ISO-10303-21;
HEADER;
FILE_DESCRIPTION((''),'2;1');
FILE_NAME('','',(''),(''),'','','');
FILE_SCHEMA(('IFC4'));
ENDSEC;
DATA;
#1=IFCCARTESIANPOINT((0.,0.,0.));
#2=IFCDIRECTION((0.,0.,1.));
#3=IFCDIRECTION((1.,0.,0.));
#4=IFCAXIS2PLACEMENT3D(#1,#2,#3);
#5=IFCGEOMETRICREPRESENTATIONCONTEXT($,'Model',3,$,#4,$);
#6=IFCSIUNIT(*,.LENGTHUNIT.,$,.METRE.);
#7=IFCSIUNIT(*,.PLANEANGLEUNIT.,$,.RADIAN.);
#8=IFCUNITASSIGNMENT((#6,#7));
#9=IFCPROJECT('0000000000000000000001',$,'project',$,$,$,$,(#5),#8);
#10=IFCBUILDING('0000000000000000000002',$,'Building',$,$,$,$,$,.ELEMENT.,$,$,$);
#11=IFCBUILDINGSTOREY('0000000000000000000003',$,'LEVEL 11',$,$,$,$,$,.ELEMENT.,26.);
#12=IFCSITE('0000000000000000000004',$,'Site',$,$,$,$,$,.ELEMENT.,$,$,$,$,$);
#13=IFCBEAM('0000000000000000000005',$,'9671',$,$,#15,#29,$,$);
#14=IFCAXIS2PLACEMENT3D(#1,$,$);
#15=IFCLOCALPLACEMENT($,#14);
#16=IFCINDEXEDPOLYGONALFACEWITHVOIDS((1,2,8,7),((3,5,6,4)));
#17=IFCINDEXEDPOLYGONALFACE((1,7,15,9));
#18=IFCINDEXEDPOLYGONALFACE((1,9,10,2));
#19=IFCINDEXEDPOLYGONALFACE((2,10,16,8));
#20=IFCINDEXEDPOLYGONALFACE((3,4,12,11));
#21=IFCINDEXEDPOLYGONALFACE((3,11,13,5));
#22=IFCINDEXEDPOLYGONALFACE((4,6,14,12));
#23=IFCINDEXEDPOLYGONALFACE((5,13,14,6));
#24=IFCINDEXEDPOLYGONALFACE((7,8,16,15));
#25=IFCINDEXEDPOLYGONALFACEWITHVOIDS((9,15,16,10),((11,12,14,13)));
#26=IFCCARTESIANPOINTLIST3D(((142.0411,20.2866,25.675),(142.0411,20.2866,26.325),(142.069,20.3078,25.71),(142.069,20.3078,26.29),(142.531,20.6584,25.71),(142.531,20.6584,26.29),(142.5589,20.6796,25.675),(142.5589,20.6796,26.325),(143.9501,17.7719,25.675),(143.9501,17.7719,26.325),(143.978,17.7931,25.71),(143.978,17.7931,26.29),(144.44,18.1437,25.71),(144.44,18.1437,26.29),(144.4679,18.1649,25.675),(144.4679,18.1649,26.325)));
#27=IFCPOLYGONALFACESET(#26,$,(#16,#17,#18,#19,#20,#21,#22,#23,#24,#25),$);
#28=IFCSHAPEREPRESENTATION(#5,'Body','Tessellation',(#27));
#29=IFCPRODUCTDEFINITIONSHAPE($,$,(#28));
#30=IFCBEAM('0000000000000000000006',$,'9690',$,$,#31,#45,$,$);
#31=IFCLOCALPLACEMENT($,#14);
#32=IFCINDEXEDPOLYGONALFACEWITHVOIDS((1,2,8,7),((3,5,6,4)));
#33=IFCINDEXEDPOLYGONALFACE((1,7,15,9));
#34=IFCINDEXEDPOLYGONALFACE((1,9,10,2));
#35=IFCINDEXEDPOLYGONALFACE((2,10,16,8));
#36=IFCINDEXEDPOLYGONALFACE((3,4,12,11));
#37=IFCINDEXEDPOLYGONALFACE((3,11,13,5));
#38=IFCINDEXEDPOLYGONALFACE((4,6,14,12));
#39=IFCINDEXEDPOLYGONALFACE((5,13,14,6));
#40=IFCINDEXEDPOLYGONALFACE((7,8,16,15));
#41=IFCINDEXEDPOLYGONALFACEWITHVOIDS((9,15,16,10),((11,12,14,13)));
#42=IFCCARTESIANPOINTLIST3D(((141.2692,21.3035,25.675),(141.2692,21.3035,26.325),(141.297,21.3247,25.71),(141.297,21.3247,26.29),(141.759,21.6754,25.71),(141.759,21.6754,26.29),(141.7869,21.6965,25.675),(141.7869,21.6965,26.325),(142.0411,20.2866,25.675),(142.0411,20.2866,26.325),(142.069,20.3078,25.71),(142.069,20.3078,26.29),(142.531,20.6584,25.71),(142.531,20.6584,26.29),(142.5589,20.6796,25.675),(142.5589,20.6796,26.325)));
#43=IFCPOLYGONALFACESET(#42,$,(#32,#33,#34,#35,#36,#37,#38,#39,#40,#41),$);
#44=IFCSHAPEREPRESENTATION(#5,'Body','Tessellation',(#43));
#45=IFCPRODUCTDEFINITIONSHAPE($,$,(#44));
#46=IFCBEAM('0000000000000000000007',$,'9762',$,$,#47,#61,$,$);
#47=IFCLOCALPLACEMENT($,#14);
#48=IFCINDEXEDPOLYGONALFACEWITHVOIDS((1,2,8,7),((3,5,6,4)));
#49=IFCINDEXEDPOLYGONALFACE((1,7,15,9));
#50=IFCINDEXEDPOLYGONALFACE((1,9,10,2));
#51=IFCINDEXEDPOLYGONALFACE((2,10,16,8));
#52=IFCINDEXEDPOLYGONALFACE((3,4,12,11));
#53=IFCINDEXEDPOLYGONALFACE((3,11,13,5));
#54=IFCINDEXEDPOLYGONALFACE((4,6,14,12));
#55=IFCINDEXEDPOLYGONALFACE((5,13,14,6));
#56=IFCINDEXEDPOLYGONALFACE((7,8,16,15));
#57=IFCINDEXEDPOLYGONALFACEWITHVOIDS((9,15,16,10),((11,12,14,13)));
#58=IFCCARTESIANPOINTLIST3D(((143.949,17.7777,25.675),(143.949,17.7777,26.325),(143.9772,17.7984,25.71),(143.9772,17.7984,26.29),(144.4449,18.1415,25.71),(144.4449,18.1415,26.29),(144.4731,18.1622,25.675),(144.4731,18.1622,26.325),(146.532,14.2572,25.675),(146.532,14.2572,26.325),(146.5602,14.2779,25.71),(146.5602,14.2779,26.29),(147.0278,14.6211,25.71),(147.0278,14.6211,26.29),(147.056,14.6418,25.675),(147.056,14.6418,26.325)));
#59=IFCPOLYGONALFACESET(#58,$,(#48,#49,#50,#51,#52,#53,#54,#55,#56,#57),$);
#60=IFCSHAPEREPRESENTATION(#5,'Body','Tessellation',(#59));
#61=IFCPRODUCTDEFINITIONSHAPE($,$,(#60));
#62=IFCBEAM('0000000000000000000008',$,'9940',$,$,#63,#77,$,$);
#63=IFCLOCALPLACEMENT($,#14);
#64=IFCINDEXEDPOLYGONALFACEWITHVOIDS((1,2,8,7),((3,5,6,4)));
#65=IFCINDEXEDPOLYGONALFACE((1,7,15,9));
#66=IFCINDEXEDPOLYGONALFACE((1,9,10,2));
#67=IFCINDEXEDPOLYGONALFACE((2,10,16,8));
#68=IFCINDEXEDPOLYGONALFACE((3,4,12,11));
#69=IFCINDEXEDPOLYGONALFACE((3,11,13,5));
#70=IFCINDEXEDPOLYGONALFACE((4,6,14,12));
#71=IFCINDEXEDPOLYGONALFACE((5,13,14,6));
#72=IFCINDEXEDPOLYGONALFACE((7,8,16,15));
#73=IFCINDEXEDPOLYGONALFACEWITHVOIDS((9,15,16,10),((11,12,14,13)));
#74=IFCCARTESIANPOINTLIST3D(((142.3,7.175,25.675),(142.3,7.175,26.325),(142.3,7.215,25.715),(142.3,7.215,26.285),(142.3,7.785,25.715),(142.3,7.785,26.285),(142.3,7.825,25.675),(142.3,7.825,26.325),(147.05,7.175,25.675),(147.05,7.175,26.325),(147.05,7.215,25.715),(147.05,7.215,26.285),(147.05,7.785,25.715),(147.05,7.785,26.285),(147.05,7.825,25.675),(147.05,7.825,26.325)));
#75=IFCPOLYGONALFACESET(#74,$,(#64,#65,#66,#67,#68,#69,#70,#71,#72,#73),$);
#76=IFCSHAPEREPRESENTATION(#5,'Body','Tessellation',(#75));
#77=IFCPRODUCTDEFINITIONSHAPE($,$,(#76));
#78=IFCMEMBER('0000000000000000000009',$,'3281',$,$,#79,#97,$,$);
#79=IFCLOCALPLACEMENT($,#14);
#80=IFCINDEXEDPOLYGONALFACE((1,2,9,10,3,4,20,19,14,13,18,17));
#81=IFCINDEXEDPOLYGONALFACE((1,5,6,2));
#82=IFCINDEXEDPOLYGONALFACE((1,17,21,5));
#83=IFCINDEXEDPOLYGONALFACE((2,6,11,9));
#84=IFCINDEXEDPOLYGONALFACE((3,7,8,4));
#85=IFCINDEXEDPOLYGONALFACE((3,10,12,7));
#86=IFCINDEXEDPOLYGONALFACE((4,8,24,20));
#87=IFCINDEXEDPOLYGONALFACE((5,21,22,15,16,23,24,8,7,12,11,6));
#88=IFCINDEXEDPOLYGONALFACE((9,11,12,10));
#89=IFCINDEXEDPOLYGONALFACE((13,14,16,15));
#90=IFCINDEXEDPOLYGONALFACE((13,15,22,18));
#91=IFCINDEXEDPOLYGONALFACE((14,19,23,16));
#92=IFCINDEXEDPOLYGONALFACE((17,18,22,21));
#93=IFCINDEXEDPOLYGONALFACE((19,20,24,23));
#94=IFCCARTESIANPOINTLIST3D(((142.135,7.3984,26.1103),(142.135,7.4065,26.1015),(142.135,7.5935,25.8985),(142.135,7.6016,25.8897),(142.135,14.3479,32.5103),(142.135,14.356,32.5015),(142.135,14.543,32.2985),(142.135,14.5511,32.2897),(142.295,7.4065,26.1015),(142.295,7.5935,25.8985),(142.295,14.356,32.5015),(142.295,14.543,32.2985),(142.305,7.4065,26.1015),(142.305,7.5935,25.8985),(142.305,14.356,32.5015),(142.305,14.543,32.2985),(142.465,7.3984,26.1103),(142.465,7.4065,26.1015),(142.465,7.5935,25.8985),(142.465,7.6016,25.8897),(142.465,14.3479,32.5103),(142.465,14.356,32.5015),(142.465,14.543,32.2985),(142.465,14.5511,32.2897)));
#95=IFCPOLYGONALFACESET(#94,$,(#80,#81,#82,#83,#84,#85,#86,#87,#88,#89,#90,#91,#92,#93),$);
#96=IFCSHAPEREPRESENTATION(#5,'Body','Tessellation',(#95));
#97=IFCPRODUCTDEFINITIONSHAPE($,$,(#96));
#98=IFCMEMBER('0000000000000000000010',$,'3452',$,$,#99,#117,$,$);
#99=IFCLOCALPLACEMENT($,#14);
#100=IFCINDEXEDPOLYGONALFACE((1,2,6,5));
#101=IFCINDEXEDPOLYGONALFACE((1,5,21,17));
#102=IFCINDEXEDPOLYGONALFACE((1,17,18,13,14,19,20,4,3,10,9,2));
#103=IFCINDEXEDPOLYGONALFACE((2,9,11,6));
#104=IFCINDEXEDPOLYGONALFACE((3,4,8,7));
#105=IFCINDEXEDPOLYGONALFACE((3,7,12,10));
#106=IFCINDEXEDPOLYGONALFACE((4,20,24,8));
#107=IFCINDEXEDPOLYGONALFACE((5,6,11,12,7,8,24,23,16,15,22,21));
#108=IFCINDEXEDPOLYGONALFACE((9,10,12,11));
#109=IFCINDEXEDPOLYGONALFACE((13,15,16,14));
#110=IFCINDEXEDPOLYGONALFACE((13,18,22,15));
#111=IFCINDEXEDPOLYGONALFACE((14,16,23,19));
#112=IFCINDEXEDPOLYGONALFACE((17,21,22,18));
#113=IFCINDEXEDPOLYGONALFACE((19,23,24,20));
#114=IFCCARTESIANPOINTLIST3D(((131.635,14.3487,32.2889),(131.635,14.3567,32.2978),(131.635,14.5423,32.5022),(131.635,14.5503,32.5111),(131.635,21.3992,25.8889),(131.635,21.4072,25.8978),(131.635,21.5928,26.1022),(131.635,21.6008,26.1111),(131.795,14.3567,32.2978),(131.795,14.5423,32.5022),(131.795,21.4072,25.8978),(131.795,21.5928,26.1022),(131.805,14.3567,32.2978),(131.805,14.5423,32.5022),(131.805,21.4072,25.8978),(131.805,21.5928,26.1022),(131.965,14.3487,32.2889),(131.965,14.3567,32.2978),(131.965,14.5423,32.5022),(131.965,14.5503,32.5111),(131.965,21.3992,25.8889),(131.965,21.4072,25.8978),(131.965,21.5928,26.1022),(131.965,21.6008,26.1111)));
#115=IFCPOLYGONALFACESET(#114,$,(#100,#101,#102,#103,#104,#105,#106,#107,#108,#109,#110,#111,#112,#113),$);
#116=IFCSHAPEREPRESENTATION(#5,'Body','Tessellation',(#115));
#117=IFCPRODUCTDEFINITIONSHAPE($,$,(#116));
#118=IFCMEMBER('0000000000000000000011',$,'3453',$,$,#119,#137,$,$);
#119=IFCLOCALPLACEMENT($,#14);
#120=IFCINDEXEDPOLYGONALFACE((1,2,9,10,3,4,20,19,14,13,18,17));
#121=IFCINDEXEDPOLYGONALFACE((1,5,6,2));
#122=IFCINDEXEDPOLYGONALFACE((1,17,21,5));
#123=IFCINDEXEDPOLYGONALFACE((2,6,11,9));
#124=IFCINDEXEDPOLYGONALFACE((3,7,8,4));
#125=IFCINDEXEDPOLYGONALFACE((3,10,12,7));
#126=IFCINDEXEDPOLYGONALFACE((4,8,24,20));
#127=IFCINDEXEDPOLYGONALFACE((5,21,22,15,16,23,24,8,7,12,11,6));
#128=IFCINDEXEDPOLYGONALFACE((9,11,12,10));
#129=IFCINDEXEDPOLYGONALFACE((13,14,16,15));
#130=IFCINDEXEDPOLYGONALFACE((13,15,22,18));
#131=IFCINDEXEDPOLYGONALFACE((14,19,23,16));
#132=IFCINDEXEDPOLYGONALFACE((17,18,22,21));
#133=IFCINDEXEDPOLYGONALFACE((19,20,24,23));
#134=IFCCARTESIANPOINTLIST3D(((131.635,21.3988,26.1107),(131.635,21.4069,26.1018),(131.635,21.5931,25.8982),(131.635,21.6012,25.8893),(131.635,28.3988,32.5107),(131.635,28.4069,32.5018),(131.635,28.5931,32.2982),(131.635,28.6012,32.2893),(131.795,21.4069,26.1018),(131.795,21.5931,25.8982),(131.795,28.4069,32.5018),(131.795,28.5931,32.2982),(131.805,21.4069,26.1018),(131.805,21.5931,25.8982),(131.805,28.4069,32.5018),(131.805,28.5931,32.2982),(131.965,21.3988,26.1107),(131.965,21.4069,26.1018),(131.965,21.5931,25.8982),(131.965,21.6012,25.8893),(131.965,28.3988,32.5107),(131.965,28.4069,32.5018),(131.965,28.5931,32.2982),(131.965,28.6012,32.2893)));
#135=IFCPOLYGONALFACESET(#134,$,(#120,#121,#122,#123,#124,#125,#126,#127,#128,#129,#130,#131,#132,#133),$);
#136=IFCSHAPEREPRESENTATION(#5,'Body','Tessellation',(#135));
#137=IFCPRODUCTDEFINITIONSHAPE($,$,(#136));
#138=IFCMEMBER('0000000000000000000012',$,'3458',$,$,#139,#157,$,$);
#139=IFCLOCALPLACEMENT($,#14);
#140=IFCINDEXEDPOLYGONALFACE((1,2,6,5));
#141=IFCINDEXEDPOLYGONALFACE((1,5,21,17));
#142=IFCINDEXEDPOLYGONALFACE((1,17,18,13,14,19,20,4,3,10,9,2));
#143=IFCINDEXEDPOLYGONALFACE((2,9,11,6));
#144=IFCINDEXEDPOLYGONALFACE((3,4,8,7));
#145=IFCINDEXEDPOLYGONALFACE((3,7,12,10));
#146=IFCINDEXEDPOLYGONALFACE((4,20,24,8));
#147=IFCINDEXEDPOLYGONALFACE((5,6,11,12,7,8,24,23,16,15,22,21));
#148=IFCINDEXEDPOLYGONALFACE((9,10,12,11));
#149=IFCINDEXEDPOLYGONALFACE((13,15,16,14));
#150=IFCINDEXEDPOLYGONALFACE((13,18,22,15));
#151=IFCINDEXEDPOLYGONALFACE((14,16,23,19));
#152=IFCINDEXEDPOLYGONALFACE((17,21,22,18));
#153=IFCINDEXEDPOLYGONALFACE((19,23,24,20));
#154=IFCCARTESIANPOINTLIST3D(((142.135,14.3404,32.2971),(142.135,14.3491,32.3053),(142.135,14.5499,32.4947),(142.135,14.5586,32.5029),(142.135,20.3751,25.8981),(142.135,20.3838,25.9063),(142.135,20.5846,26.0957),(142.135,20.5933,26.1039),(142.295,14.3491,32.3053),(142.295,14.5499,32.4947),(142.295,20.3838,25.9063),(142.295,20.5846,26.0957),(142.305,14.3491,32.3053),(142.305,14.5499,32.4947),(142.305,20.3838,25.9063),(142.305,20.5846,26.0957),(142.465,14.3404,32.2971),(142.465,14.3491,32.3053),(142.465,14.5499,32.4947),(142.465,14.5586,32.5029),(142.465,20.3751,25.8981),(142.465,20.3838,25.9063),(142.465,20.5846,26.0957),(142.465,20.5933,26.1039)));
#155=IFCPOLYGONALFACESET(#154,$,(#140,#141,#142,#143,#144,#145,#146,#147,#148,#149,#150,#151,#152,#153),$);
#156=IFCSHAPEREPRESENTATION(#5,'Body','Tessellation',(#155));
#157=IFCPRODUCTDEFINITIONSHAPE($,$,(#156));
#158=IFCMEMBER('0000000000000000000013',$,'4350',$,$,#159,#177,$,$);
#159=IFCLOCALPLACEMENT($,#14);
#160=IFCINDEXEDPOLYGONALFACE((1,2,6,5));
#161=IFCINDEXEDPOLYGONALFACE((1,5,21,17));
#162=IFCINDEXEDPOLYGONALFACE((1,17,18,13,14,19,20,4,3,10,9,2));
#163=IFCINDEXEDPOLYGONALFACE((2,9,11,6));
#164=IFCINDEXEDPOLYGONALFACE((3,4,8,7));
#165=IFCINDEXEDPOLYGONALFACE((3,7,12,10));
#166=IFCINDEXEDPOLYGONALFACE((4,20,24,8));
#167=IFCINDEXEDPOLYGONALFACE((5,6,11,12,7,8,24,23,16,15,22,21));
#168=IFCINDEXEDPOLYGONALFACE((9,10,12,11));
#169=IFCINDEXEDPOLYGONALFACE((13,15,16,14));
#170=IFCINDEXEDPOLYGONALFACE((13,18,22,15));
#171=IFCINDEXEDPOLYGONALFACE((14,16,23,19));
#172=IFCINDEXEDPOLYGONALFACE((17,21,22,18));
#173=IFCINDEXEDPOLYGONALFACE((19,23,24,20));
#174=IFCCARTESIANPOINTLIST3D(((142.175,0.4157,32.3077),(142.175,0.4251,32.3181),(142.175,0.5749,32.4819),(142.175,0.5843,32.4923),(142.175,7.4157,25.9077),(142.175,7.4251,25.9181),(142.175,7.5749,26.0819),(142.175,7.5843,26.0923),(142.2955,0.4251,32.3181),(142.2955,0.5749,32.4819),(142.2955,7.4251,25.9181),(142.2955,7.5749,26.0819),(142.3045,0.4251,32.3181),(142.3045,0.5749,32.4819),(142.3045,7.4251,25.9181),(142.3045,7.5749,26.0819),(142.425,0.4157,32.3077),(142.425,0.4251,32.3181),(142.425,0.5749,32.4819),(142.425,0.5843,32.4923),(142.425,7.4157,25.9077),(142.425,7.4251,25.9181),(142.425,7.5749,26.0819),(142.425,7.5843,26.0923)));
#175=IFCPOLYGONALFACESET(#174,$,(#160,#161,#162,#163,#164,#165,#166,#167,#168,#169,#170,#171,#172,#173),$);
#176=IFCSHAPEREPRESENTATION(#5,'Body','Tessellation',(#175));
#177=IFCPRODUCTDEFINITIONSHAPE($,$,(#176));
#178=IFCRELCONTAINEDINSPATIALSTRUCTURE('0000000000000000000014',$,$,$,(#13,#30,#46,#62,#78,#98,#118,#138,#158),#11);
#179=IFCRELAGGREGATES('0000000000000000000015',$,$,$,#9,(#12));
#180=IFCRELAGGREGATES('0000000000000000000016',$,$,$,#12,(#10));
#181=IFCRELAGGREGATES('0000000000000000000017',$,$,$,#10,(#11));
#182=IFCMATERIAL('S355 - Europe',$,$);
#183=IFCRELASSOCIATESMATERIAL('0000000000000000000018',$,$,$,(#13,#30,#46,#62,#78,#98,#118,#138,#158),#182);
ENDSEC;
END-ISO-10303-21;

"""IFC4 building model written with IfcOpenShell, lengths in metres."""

from ifc_helpers import new_model, si_unit, frame, origin_with_axes, origin_2d_with_axis, place, context, project, spatial, hollow_rectangle, i_section, extrude, material, material_profile, profile_set, profile_usage, element, save


model = new_model("IFC4")

# Units and contexts
model_context = context("Model", 3, world=origin_with_axes())
ifc_project = project(units=[si_unit("LENGTHUNIT", "METRE"), si_unit("PLANEANGLEUNIT", "RADIAN")], contexts=[model_context])

# Site, building, storey
site = spatial("IfcSite", under=ifc_project, Name="Site", CompositionType="ELEMENT")
building = spatial("IfcBuilding", under=site, Name="Building", CompositionType="ELEMENT")
storey = spatial("IfcBuildingStorey", under=building, Name="LEVEL 11", CompositionType="ELEMENT", Elevation=26.0)

# Shared definitions
ifc_material = material(Name="S355 - Europe")

# Beams
ifc_material_profile_1 = material_profile(ifc_material, hollow_rectangle(XDim=0.65, YDim=0.65, WallThickness=0.035, at=origin_2d_with_axis()))
ifc_profile_set_1 = profile_set([ifc_material_profile_1])
ifc_profile_usage_1 = profile_usage(ifc_profile_set_1, cardinal=10)
beam_1_placement = place(None, frame((144.209, 17.9684, 26.0), z_axis=(-0.604647, 0.796493, 0.0), x_axis=(-0.796493, -0.604647, 0.0)))
element("IfcBeam", 1, at=beam_1_placement, inside=storey, material=ifc_profile_usage_1, Name="9671", context=model_context, shape_type="SweptSolid", body=[
    extrude(hollow_rectangle(XDim=0.65, YDim=0.65, WallThickness=0.035, at=origin_2d_with_axis()), origin_with_axes(), (0.0, 0.0, 1.0), 3.1572),
])
ifc_material_profile_2 = material_profile(ifc_material, hollow_rectangle(XDim=0.65, YDim=0.65, WallThickness=0.035, at=origin_2d_with_axis()))
ifc_profile_set_2 = profile_set([ifc_material_profile_2])
ifc_profile_usage_2 = profile_usage(ifc_profile_set_2, cardinal=10)
beam_2_placement = place(None, frame((142.3, 20.4831, 26.0), z_axis=(-0.604647, 0.796493, 0.0), x_axis=(-0.796493, -0.604647, 0.0)))
element("IfcBeam", 2, at=beam_2_placement, inside=storey, material=ifc_profile_usage_2, Name="9690", context=model_context, shape_type="SweptSolid", body=[
    extrude(hollow_rectangle(XDim=0.65, YDim=0.65, WallThickness=0.035, at=origin_2d_with_axis()), origin_with_axes(), (0.0, 0.0, 1.0), 1.2767),
])
ifc_material_profile_3 = material_profile(ifc_material, hollow_rectangle(XDim=0.65, YDim=0.65, WallThickness=0.035, at=origin_2d_with_axis()))
ifc_profile_set_3 = profile_set([ifc_material_profile_3])
ifc_profile_usage_3 = profile_usage(ifc_profile_set_3, cardinal=10)
beam_3_placement = place(None, frame((146.794, 14.4495, 26.0), z_axis=(-0.591557, 0.806263, 0.0), x_axis=(-0.805765, -0.592235, 0.0)))
element("IfcBeam", 3, at=beam_3_placement, inside=storey, material=ifc_profile_usage_3, Name="9762", context=model_context, shape_type="SweptSolid", body=[
    extrude(hollow_rectangle(XDim=0.65, YDim=0.65, WallThickness=0.035, at=origin_2d_with_axis()), origin_with_axes(), (0.0, 0.0, 1.0), 4.3663),
])
ifc_material_profile_4 = material_profile(ifc_material, hollow_rectangle(XDim=0.65, YDim=0.65, WallThickness=0.04, at=origin_2d_with_axis()))
ifc_profile_set_4 = profile_set([ifc_material_profile_4])
ifc_profile_usage_4 = profile_usage(ifc_profile_set_4, cardinal=10)
beam_4_placement = place(None, frame((142.3, 7.5, 26.0), z_axis=(1.0, 0.0, 0.0), x_axis=(0.0, 1.0, 0.0)))
element("IfcBeam", 4, at=beam_4_placement, inside=storey, material=ifc_profile_usage_4, Name="9940", context=model_context, shape_type="SweptSolid", body=[
    extrude(hollow_rectangle(XDim=0.65, YDim=0.65, WallThickness=0.04, at=origin_2d_with_axis()), origin_with_axes(), (0.0, 0.0, 1.0), 4.75),
])

# Members
ifc_material_profile_5 = material_profile(ifc_material, i_section(OverallWidth=0.33, OverallDepth=0.3, WebThickness=0.01, FlangeThickness=0.012, at=origin_2d_with_axis()))
ifc_profile_set_5 = profile_set([ifc_material_profile_5])
ifc_profile_usage_5 = profile_usage(ifc_profile_set_5, cardinal=10)
member_1_placement = place(None, frame((142.3, 7.5, 26.0), z_axis=(0.0, 0.73559, 0.677427), x_axis=(-1.0, 0.0, 0.0)))
element("IfcMember", 5, at=member_1_placement, inside=storey, material=ifc_profile_usage_5, Name="3281", context=model_context, shape_type="SweptSolid", body=[
    extrude(i_section(OverallWidth=0.33, OverallDepth=0.3, WebThickness=0.01, FlangeThickness=0.012, at=origin_2d_with_axis()), origin_with_axes(), (0.0, 0.0, 1.0), 9.4475),
])
ifc_material_profile_6 = material_profile(ifc_material, i_section(OverallWidth=0.33, OverallDepth=0.3, WebThickness=0.01, FlangeThickness=0.012, at=origin_2d_with_axis()))
ifc_profile_set_6 = profile_set([ifc_material_profile_6])
ifc_profile_usage_6 = profile_usage(ifc_profile_set_6, cardinal=10)
member_2_placement = place(None, frame((131.8, 14.4495, 32.4), z_axis=(0.0, 0.740439, -0.672124), x_axis=(-1.0, 0.0, 0.0)))
element("IfcMember", 6, at=member_2_placement, inside=storey, material=ifc_profile_usage_6, Name="3452", context=model_context, shape_type="SweptSolid", body=[
    extrude(i_section(OverallWidth=0.33, OverallDepth=0.3, WebThickness=0.01, FlangeThickness=0.012, at=origin_2d_with_axis()), origin_with_axes(), (0.0, 0.0, 1.0), 9.5221),
])
ifc_material_profile_7 = material_profile(ifc_material, i_section(OverallWidth=0.33, OverallDepth=0.3, WebThickness=0.01, FlangeThickness=0.012, at=origin_2d_with_axis()))
ifc_profile_set_7 = profile_set([ifc_material_profile_7])
ifc_profile_usage_7 = profile_usage(ifc_profile_set_7, cardinal=10)
member_3_placement = place(None, frame((131.8, 21.5, 26.0), z_axis=(0.0, 0.738029, 0.674769), x_axis=(-1.0, 0.0, 0.0)))
element("IfcMember", 7, at=member_3_placement, inside=storey, material=ifc_profile_usage_7, Name="3453", context=model_context, shape_type="SweptSolid", body=[
    extrude(i_section(OverallWidth=0.33, OverallDepth=0.3, WebThickness=0.01, FlangeThickness=0.012, at=origin_2d_with_axis()), origin_with_axes(), (0.0, 0.0, 1.0), 9.4847),
])
ifc_material_profile_8 = material_profile(ifc_material, i_section(OverallWidth=0.33, OverallDepth=0.3, WebThickness=0.01, FlangeThickness=0.012, at=origin_2d_with_axis()))
ifc_profile_set_8 = profile_set([ifc_material_profile_8])
ifc_profile_usage_8 = profile_usage(ifc_profile_set_8, cardinal=10)
member_4_placement = place(None, frame((142.3, 14.4495, 32.4), z_axis=(0.0, 0.686094, -0.727512), x_axis=(-1.0, 0.0, 0.0)))
element("IfcMember", 8, at=member_4_placement, inside=storey, material=ifc_profile_usage_8, Name="3458", context=model_context, shape_type="SweptSolid", body=[
    extrude(i_section(OverallWidth=0.33, OverallDepth=0.3, WebThickness=0.01, FlangeThickness=0.012, at=origin_2d_with_axis()), origin_with_axes(), (0.0, 0.0, 1.0), 8.7957),
])
ifc_material_profile_9 = material_profile(ifc_material, i_section(OverallWidth=0.25, OverallDepth=0.25, WebThickness=0.009, FlangeThickness=0.014, at=origin_2d_with_axis()))
ifc_profile_set_9 = profile_set([ifc_material_profile_9])
ifc_profile_usage_9 = profile_usage(ifc_profile_set_9, cardinal=10)
member_5_placement = place(None, frame((142.3, 7.5, 26.0), z_axis=(0.0, -0.738029, 0.674769), x_axis=(1.0, 0.0, 0.0)))
element("IfcMember", 9, at=member_5_placement, inside=storey, material=ifc_profile_usage_9, Name="4350", context=model_context, shape_type="SweptSolid", body=[
    extrude(i_section(OverallWidth=0.25, OverallDepth=0.25, WebThickness=0.009, FlangeThickness=0.014, at=origin_2d_with_axis()), origin_with_axes(), (0.0, 0.0, 1.0), 9.4847),
])

save(model, "model.ifc")
